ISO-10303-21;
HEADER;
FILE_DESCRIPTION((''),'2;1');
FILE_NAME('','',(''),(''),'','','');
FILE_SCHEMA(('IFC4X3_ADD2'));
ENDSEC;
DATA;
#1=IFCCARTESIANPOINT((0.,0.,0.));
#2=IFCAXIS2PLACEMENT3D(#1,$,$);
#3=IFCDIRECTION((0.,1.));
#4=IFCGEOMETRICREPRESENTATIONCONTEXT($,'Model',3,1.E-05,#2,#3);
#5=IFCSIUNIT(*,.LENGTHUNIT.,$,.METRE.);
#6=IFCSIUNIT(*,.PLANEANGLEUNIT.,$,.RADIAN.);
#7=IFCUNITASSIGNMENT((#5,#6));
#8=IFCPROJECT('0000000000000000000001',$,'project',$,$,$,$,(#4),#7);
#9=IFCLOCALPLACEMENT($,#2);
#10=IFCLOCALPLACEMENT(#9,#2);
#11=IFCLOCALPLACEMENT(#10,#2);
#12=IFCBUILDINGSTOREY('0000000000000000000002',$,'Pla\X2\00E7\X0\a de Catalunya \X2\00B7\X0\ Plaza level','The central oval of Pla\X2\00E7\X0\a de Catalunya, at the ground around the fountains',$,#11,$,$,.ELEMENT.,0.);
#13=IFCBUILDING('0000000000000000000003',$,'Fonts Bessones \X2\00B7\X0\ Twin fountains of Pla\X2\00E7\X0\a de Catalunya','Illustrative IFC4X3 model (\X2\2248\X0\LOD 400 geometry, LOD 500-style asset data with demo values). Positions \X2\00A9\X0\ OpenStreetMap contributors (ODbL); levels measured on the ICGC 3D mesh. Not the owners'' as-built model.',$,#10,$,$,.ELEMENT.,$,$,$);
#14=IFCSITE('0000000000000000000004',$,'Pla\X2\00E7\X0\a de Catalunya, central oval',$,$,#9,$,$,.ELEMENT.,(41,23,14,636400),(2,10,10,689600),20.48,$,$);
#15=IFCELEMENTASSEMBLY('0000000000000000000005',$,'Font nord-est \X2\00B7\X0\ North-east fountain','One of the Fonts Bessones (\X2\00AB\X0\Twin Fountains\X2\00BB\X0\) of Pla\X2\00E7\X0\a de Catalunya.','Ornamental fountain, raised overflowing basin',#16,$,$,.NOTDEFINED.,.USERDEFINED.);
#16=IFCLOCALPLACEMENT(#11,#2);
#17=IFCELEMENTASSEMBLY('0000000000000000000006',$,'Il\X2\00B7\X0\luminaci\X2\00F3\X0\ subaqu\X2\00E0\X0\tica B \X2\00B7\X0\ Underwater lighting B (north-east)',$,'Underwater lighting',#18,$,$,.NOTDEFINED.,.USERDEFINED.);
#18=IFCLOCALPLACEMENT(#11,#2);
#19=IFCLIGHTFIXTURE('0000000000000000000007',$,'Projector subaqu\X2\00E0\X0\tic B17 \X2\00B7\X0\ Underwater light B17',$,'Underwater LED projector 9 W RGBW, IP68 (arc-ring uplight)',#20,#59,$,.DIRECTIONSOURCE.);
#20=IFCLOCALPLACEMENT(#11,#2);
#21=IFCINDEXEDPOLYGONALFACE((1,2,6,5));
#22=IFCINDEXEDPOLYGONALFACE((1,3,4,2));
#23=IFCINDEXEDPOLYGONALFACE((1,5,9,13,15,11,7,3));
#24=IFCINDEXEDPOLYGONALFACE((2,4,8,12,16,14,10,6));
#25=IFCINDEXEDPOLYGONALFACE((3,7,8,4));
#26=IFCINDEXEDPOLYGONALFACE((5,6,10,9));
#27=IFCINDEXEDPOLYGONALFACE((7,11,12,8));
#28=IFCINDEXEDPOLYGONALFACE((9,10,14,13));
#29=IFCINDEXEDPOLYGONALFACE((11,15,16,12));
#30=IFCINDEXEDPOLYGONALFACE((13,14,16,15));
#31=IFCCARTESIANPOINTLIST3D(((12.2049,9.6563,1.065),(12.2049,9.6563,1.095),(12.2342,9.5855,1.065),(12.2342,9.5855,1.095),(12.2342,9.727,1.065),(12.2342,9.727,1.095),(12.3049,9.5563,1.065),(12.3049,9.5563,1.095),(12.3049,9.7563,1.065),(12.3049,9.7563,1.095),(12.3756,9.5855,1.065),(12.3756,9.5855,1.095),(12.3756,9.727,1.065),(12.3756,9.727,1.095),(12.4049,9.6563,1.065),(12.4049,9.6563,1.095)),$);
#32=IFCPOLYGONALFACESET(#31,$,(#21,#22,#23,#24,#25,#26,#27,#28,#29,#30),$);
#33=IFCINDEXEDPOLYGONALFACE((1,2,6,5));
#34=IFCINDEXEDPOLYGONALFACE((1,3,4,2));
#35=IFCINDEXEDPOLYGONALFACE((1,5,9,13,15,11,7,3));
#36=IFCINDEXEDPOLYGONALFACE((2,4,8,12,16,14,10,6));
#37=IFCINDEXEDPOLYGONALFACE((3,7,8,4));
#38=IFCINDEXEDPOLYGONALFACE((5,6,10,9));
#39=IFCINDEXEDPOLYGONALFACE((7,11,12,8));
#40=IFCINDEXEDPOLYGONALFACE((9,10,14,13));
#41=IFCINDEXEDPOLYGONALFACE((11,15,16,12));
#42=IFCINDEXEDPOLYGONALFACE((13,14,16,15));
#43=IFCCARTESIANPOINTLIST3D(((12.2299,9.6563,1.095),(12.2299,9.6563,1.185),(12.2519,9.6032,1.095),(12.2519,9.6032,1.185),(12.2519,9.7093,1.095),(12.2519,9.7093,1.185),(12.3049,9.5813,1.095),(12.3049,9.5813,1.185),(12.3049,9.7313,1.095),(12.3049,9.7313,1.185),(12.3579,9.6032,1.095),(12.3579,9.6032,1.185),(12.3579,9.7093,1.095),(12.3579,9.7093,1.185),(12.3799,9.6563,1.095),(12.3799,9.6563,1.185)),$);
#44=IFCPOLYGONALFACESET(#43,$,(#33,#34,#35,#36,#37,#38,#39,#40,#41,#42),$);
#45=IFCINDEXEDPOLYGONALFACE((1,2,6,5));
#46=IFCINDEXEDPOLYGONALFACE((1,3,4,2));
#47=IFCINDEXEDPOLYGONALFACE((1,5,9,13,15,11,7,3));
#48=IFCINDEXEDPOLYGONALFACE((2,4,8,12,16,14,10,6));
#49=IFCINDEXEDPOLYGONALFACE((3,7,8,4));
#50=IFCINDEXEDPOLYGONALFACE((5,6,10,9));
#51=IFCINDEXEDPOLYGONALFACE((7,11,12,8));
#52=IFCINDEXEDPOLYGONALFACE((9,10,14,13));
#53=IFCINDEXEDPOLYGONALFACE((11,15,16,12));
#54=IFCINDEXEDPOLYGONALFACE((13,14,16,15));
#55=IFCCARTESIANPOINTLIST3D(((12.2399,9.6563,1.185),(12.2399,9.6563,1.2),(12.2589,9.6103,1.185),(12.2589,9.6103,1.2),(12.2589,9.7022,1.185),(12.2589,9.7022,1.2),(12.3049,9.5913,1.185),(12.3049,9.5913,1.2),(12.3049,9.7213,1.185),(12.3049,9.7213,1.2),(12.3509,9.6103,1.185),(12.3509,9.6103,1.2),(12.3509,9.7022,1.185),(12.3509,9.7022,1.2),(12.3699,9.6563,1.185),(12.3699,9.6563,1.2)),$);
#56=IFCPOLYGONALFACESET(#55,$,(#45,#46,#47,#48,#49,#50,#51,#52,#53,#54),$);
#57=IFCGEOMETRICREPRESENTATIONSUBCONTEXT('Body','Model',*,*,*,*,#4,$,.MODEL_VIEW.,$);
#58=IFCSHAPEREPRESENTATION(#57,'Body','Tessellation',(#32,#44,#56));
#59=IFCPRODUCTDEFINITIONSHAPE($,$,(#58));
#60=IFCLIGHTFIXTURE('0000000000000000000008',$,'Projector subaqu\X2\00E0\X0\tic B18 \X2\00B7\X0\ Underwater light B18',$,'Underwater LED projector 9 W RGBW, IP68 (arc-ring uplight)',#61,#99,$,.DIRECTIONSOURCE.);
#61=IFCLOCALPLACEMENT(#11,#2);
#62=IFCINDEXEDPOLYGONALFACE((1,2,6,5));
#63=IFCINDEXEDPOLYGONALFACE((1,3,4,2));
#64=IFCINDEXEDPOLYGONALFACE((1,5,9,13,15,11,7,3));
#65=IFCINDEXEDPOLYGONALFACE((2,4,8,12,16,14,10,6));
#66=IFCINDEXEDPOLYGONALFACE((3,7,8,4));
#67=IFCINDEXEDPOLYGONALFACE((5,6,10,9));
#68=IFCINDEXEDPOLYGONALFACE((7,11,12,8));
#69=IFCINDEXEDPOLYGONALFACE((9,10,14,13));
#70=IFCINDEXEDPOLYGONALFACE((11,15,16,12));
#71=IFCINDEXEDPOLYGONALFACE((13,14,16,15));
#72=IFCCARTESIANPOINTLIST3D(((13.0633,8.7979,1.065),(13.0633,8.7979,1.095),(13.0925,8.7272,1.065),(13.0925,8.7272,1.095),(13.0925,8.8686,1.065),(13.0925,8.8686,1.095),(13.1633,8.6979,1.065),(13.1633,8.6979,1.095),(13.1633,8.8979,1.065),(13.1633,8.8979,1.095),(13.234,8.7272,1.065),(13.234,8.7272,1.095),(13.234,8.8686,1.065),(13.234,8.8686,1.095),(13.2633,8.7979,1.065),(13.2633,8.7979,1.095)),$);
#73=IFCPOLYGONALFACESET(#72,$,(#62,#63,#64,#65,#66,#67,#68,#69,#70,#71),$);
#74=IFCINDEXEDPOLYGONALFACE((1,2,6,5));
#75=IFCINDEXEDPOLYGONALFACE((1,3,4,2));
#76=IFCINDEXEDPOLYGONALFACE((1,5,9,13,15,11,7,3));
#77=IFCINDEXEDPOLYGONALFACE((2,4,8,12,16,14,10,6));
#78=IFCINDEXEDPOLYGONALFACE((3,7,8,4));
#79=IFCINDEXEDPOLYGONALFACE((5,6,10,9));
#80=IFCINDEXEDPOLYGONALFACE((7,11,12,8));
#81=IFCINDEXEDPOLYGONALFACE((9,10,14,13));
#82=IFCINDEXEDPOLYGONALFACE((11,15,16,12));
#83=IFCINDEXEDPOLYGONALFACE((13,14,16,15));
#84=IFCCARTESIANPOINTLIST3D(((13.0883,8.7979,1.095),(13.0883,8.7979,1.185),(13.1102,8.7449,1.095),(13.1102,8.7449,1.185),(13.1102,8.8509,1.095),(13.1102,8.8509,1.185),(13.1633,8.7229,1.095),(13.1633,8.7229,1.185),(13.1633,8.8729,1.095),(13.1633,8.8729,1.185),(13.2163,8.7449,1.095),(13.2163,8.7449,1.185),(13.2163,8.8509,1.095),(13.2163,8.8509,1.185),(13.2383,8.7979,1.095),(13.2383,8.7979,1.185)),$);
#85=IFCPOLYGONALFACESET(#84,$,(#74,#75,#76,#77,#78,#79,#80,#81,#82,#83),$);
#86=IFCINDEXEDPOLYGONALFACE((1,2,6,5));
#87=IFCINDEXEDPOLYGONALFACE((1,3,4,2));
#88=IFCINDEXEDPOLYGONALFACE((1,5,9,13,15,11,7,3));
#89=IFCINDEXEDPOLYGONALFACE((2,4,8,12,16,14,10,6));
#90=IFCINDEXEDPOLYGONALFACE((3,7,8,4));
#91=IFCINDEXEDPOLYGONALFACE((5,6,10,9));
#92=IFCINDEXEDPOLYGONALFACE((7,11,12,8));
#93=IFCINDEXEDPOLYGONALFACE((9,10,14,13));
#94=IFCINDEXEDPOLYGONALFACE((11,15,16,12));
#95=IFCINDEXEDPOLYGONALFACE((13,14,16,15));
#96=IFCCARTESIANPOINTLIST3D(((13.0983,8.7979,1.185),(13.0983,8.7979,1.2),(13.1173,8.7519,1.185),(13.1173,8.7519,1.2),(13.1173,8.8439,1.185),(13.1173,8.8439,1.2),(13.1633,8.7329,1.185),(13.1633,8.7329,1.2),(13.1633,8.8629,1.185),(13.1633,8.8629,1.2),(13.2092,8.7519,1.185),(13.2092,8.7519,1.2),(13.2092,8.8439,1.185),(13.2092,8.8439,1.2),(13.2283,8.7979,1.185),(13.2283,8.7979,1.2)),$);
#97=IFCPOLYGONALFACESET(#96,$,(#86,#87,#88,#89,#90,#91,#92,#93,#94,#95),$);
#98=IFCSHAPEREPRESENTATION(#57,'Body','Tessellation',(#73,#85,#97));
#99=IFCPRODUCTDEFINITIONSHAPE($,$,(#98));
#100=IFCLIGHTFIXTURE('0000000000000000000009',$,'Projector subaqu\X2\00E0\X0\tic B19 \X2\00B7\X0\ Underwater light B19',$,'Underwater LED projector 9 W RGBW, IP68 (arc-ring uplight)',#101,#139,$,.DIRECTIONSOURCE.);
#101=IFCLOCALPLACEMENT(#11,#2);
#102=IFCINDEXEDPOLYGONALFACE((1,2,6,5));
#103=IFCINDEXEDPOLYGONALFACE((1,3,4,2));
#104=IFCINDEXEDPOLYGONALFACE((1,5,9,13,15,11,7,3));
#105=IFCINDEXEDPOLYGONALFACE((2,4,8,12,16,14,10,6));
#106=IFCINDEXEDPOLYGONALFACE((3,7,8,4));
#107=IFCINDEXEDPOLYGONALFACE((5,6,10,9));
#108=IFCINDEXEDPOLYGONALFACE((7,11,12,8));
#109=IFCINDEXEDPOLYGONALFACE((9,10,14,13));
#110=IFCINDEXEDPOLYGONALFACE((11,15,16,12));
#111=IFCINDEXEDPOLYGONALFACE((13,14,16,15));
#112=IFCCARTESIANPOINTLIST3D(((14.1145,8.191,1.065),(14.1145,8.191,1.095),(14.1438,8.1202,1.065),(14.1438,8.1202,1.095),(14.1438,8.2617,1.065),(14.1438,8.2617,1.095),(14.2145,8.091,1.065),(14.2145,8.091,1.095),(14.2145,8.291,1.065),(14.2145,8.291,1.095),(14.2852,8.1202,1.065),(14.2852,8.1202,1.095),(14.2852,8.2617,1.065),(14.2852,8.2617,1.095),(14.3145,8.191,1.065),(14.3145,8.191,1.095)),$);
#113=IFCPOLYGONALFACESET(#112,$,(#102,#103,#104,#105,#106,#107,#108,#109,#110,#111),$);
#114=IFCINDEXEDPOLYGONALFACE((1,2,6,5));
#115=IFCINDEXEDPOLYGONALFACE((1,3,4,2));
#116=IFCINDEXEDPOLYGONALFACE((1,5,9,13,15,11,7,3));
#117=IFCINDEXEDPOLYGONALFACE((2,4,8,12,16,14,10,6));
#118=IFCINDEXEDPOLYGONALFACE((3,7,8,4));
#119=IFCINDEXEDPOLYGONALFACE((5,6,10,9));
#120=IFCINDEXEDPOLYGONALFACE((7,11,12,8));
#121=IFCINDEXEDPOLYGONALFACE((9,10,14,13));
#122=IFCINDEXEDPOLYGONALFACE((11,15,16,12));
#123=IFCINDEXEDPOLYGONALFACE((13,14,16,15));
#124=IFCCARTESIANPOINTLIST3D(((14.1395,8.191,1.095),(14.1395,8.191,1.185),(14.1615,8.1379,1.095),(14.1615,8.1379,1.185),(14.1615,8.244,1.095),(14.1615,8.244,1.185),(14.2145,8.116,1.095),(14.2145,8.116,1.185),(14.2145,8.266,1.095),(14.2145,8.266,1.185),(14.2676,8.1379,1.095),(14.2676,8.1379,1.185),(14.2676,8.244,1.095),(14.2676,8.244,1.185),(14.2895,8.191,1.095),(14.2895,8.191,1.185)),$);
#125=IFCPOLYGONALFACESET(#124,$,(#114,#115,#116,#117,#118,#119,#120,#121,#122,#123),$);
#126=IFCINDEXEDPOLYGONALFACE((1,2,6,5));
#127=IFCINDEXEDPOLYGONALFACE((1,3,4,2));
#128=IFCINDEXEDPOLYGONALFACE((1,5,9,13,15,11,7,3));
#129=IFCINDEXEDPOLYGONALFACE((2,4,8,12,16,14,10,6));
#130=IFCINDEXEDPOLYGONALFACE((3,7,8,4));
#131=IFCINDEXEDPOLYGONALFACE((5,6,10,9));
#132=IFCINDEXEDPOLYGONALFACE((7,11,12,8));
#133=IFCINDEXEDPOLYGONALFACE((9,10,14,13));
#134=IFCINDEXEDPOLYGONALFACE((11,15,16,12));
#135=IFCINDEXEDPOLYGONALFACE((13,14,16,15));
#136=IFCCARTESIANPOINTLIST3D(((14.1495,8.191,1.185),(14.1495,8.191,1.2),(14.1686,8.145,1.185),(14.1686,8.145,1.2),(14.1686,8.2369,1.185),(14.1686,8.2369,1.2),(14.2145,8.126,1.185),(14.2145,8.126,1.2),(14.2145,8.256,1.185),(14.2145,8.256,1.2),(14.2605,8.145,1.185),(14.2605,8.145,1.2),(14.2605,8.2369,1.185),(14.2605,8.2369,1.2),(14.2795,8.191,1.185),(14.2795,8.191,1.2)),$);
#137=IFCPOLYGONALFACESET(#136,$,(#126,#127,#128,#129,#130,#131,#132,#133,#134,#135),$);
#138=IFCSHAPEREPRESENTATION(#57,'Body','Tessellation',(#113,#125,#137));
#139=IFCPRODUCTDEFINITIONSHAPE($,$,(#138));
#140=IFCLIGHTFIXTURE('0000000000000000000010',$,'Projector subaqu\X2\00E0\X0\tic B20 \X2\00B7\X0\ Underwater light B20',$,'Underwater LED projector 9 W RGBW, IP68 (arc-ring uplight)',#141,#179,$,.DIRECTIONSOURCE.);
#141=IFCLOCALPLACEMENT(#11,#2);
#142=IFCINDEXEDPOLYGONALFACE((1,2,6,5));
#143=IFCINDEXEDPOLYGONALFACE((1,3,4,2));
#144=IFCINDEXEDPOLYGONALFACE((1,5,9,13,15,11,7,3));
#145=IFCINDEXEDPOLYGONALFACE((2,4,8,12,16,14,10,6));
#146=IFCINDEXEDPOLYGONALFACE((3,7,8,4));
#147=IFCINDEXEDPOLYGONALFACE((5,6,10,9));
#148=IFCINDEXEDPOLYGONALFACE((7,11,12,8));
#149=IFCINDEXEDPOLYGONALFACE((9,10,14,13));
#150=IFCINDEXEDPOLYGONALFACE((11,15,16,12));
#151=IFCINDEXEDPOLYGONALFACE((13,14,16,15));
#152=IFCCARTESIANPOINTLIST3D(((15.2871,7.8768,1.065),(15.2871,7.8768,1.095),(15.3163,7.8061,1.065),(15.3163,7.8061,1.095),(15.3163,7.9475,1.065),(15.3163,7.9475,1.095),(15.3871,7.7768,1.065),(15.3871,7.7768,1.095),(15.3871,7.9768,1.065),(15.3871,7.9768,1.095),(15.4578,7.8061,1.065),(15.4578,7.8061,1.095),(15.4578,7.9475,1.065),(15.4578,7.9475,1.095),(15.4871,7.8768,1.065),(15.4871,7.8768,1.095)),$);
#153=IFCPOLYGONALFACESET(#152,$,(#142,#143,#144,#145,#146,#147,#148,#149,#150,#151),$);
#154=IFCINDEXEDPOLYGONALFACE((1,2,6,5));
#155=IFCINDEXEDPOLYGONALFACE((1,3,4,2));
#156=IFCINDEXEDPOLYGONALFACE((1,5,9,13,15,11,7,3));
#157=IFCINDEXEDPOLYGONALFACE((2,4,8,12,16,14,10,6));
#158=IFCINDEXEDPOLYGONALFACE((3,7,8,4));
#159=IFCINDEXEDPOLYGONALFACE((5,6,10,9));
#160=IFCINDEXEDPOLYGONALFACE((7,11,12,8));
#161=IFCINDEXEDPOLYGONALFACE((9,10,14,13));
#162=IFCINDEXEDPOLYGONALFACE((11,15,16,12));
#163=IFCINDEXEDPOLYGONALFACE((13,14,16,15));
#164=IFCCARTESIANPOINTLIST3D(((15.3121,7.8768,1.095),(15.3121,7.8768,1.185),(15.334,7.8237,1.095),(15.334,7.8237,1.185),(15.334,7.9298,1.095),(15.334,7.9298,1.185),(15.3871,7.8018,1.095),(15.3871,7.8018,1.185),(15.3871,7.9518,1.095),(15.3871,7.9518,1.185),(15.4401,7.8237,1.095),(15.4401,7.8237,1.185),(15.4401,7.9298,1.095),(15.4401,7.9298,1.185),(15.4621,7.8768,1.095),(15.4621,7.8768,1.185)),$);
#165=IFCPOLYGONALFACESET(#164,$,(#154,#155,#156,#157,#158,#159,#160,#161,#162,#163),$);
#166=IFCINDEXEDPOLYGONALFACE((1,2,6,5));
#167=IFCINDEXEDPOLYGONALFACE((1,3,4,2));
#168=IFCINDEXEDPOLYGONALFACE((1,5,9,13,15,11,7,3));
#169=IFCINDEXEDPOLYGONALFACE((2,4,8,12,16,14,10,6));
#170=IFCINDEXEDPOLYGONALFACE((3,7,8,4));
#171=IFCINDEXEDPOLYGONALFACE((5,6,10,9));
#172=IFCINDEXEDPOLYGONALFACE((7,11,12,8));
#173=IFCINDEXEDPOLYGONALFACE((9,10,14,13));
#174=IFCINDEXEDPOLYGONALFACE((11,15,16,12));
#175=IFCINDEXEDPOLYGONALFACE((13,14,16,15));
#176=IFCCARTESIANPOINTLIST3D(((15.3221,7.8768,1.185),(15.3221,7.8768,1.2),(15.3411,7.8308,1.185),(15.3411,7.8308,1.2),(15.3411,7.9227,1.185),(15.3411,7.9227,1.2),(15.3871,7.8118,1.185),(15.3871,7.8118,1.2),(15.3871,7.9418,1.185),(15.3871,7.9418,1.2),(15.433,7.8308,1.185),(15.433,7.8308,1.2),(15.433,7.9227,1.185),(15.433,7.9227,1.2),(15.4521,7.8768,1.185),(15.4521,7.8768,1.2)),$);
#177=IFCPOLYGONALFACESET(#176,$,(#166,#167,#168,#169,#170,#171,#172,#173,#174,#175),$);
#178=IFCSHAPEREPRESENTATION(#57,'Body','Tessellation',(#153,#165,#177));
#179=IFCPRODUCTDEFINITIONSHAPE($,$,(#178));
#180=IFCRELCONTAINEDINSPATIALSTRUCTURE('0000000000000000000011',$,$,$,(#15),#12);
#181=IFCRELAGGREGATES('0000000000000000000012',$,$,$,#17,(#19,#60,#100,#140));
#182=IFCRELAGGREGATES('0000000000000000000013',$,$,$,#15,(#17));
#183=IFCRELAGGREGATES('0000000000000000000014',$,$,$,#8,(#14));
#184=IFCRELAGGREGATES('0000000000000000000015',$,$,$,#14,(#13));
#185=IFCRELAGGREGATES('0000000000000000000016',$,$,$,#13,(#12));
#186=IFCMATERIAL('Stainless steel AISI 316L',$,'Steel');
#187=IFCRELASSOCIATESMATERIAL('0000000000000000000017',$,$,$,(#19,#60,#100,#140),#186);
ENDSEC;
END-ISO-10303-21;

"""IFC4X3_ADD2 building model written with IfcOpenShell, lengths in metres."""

from ifc_helpers import new_model, si_unit, direction, frame, origin, place, context, subcontext, project, spatial, polyline, outline, extrude, material, element, aggregate, save


model = new_model("IFC4X3_ADD2")

# Units and contexts
model_context = context("Model", 3, precision=1e-05, world=origin(), true_north=direction((0.0, 1.0)))
body_context = subcontext(model_context, "Body", "Model", "MODEL_VIEW")
ifc_project = project(units=[si_unit("LENGTHUNIT", "METRE"), si_unit("PLANEANGLEUNIT", "RADIAN")], contexts=[model_context])

# Site, building, storey
site_placement = place(None, origin())
site = spatial("IfcSite", under=ifc_project, at=site_placement, Name="Plaça de Catalunya, central oval", CompositionType="ELEMENT", RefLatitude=(41, 23, 14, 636400), RefLongitude=(2, 10, 10, 689600), RefElevation=20.48)
building_placement = place(site_placement, origin())
building = spatial("IfcBuilding", under=site, at=building_placement, Name="Fonts Bessones · Twin fountains of Plaça de Catalunya", Description="Illustrative IFC4X3 model (≈LOD 400 geometry, LOD 500-style asset data with demo values). Positions © OpenStreetMap contributors (ODbL); levels measured on the ICGC 3D mesh. Not the owners' as-built model.", CompositionType="ELEMENT")
storey_placement = place(building_placement, origin())
storey = spatial("IfcBuildingStorey", under=building, at=storey_placement, Name="Plaça de Catalunya · Plaza level", Description="The central oval of Plaça de Catalunya, at the ground around the fountains", CompositionType="ELEMENT", Elevation=0.0)

# Element assemblies, light fixtures
assembly_1_placement = place(building_placement, origin())
assembly_1 = element("IfcElementAssembly", 1, at=assembly_1_placement, inside=storey, Name="Font nord-est · North-east fountain", Description="One of the Fonts Bessones («Twin Fountains») of Plaça de Catalunya.", ObjectType="Ornamental fountain, raised overflowing basin", AssemblyPlace="NOTDEFINED", PredefinedType="USERDEFINED")
assembly_2_placement = place(building_placement, origin())
assembly_2 = element("IfcElementAssembly", 2, at=assembly_2_placement, Name="Il·luminació subaquàtica B · Underwater lighting B (north-east)", ObjectType="Underwater lighting", AssemblyPlace="NOTDEFINED", PredefinedType="USERDEFINED")
ifc_material_1 = material(Name="Stainless steel AISI 316L", Category="Steel")
light_fixture_1_placement = place(building_placement, origin())
light_fixture_1 = element("IfcLightFixture", 3, at=light_fixture_1_placement, material=ifc_material_1, Name="Projector subaquàtic B17 · Underwater light B17", ObjectType="Underwater LED projector 9 W RGBW, IP68 (arc-ring uplight)", PredefinedType="DIRECTIONSOURCE", context=body_context, shape_type="SweptSolid", body=[
    extrude(outline(polyline([(12.4049, 9.6563), (12.3756, 9.727), (12.3049, 9.7563), (12.2342, 9.727), (12.2049, 9.6563), (12.2342, 9.5855), (12.3049, 9.5563), (12.3756, 9.5855), (12.4049, 9.6563)])), frame((0.0, 0.0, 1.065)), (0.0, 0.0, 1.0), 0.03),
    extrude(outline(polyline([(12.3799, 9.6563), (12.3579, 9.7093), (12.3049, 9.7313), (12.2519, 9.7093), (12.2299, 9.6563), (12.2519, 9.6032), (12.3049, 9.5813), (12.3579, 9.6032), (12.3799, 9.6563)])), frame((0.0, 0.0, 1.095)), (0.0, 0.0, 1.0), 0.09),
    extrude(outline(polyline([(12.3699, 9.6563), (12.3509, 9.7022), (12.3049, 9.7213), (12.2589, 9.7022), (12.2399, 9.6563), (12.2589, 9.6103), (12.3049, 9.5913), (12.3509, 9.6103), (12.3699, 9.6563)])), frame((0.0, 0.0, 1.185)), (0.0, 0.0, 1.0), 0.015),
])
light_fixture_2_placement = place(building_placement, origin())
light_fixture_2 = element("IfcLightFixture", 4, at=light_fixture_2_placement, material=ifc_material_1, Name="Projector subaquàtic B18 · Underwater light B18", ObjectType="Underwater LED projector 9 W RGBW, IP68 (arc-ring uplight)", PredefinedType="DIRECTIONSOURCE", context=body_context, shape_type="SweptSolid", body=[
    extrude(outline(polyline([(13.2633, 8.7979), (13.234, 8.8686), (13.1633, 8.8979), (13.0925, 8.8686), (13.0633, 8.7979), (13.0925, 8.7272), (13.1633, 8.6979), (13.234, 8.7272), (13.2633, 8.7979)])), frame((0.0, 0.0, 1.065)), (0.0, 0.0, 1.0), 0.03),
    extrude(outline(polyline([(13.2383, 8.7979), (13.2163, 8.8509), (13.1633, 8.8729), (13.1102, 8.8509), (13.0883, 8.7979), (13.1102, 8.7449), (13.1633, 8.7229), (13.2163, 8.7449), (13.2383, 8.7979)])), frame((0.0, 0.0, 1.095)), (0.0, 0.0, 1.0), 0.09),
    extrude(outline(polyline([(13.2283, 8.7979), (13.2092, 8.8439), (13.1633, 8.8629), (13.1173, 8.8439), (13.0983, 8.7979), (13.1173, 8.7519), (13.1633, 8.7329), (13.2092, 8.7519), (13.2283, 8.7979)])), frame((0.0, 0.0, 1.185)), (0.0, 0.0, 1.0), 0.015),
])
light_fixture_3_placement = place(building_placement, origin())
light_fixture_3 = element("IfcLightFixture", 5, at=light_fixture_3_placement, material=ifc_material_1, Name="Projector subaquàtic B19 · Underwater light B19", ObjectType="Underwater LED projector 9 W RGBW, IP68 (arc-ring uplight)", PredefinedType="DIRECTIONSOURCE", context=body_context, shape_type="SweptSolid", body=[
    extrude(outline(polyline([(14.3145, 8.191), (14.2852, 8.2617), (14.2145, 8.291), (14.1438, 8.2617), (14.1145, 8.191), (14.1438, 8.1202), (14.2145, 8.091), (14.2852, 8.1202), (14.3145, 8.191)])), frame((0.0, 0.0, 1.065)), (0.0, 0.0, 1.0), 0.03),
    extrude(outline(polyline([(14.2895, 8.191), (14.2676, 8.244), (14.2145, 8.266), (14.1615, 8.244), (14.1395, 8.191), (14.1615, 8.1379), (14.2145, 8.116), (14.2676, 8.1379), (14.2895, 8.191)])), frame((0.0, 0.0, 1.095)), (0.0, 0.0, 1.0), 0.09),
    extrude(outline(polyline([(14.2795, 8.191), (14.2605, 8.2369), (14.2145, 8.256), (14.1686, 8.2369), (14.1495, 8.191), (14.1686, 8.145), (14.2145, 8.126), (14.2605, 8.145), (14.2795, 8.191)])), frame((0.0, 0.0, 1.185)), (0.0, 0.0, 1.0), 0.015),
])
light_fixture_4_placement = place(building_placement, origin())
light_fixture_4 = element("IfcLightFixture", 6, at=light_fixture_4_placement, material=ifc_material_1, Name="Projector subaquàtic B20 · Underwater light B20", ObjectType="Underwater LED projector 9 W RGBW, IP68 (arc-ring uplight)", PredefinedType="DIRECTIONSOURCE", context=body_context, shape_type="SweptSolid", body=[
    extrude(outline(polyline([(15.4871, 7.8768), (15.4578, 7.9475), (15.3871, 7.9768), (15.3163, 7.9475), (15.2871, 7.8768), (15.3163, 7.8061), (15.3871, 7.7768), (15.4578, 7.8061), (15.4871, 7.8768)])), frame((0.0, 0.0, 1.065)), (0.0, 0.0, 1.0), 0.03),
    extrude(outline(polyline([(15.4621, 7.8768), (15.4401, 7.9298), (15.3871, 7.9518), (15.334, 7.9298), (15.3121, 7.8768), (15.334, 7.8237), (15.3871, 7.8018), (15.4401, 7.8237), (15.4621, 7.8768)])), frame((0.0, 0.0, 1.095)), (0.0, 0.0, 1.0), 0.09),
    extrude(outline(polyline([(15.4521, 7.8768), (15.433, 7.9227), (15.3871, 7.9418), (15.3411, 7.9227), (15.3221, 7.8768), (15.3411, 7.8308), (15.3871, 7.8118), (15.433, 7.8308), (15.4521, 7.8768)])), frame((0.0, 0.0, 1.185)), (0.0, 0.0, 1.0), 0.015),
])
aggregate(assembly_2, [light_fixture_1, light_fixture_2, light_fixture_3, light_fixture_4])
aggregate(assembly_1, [assembly_2])

save(model, "model.ifc")
